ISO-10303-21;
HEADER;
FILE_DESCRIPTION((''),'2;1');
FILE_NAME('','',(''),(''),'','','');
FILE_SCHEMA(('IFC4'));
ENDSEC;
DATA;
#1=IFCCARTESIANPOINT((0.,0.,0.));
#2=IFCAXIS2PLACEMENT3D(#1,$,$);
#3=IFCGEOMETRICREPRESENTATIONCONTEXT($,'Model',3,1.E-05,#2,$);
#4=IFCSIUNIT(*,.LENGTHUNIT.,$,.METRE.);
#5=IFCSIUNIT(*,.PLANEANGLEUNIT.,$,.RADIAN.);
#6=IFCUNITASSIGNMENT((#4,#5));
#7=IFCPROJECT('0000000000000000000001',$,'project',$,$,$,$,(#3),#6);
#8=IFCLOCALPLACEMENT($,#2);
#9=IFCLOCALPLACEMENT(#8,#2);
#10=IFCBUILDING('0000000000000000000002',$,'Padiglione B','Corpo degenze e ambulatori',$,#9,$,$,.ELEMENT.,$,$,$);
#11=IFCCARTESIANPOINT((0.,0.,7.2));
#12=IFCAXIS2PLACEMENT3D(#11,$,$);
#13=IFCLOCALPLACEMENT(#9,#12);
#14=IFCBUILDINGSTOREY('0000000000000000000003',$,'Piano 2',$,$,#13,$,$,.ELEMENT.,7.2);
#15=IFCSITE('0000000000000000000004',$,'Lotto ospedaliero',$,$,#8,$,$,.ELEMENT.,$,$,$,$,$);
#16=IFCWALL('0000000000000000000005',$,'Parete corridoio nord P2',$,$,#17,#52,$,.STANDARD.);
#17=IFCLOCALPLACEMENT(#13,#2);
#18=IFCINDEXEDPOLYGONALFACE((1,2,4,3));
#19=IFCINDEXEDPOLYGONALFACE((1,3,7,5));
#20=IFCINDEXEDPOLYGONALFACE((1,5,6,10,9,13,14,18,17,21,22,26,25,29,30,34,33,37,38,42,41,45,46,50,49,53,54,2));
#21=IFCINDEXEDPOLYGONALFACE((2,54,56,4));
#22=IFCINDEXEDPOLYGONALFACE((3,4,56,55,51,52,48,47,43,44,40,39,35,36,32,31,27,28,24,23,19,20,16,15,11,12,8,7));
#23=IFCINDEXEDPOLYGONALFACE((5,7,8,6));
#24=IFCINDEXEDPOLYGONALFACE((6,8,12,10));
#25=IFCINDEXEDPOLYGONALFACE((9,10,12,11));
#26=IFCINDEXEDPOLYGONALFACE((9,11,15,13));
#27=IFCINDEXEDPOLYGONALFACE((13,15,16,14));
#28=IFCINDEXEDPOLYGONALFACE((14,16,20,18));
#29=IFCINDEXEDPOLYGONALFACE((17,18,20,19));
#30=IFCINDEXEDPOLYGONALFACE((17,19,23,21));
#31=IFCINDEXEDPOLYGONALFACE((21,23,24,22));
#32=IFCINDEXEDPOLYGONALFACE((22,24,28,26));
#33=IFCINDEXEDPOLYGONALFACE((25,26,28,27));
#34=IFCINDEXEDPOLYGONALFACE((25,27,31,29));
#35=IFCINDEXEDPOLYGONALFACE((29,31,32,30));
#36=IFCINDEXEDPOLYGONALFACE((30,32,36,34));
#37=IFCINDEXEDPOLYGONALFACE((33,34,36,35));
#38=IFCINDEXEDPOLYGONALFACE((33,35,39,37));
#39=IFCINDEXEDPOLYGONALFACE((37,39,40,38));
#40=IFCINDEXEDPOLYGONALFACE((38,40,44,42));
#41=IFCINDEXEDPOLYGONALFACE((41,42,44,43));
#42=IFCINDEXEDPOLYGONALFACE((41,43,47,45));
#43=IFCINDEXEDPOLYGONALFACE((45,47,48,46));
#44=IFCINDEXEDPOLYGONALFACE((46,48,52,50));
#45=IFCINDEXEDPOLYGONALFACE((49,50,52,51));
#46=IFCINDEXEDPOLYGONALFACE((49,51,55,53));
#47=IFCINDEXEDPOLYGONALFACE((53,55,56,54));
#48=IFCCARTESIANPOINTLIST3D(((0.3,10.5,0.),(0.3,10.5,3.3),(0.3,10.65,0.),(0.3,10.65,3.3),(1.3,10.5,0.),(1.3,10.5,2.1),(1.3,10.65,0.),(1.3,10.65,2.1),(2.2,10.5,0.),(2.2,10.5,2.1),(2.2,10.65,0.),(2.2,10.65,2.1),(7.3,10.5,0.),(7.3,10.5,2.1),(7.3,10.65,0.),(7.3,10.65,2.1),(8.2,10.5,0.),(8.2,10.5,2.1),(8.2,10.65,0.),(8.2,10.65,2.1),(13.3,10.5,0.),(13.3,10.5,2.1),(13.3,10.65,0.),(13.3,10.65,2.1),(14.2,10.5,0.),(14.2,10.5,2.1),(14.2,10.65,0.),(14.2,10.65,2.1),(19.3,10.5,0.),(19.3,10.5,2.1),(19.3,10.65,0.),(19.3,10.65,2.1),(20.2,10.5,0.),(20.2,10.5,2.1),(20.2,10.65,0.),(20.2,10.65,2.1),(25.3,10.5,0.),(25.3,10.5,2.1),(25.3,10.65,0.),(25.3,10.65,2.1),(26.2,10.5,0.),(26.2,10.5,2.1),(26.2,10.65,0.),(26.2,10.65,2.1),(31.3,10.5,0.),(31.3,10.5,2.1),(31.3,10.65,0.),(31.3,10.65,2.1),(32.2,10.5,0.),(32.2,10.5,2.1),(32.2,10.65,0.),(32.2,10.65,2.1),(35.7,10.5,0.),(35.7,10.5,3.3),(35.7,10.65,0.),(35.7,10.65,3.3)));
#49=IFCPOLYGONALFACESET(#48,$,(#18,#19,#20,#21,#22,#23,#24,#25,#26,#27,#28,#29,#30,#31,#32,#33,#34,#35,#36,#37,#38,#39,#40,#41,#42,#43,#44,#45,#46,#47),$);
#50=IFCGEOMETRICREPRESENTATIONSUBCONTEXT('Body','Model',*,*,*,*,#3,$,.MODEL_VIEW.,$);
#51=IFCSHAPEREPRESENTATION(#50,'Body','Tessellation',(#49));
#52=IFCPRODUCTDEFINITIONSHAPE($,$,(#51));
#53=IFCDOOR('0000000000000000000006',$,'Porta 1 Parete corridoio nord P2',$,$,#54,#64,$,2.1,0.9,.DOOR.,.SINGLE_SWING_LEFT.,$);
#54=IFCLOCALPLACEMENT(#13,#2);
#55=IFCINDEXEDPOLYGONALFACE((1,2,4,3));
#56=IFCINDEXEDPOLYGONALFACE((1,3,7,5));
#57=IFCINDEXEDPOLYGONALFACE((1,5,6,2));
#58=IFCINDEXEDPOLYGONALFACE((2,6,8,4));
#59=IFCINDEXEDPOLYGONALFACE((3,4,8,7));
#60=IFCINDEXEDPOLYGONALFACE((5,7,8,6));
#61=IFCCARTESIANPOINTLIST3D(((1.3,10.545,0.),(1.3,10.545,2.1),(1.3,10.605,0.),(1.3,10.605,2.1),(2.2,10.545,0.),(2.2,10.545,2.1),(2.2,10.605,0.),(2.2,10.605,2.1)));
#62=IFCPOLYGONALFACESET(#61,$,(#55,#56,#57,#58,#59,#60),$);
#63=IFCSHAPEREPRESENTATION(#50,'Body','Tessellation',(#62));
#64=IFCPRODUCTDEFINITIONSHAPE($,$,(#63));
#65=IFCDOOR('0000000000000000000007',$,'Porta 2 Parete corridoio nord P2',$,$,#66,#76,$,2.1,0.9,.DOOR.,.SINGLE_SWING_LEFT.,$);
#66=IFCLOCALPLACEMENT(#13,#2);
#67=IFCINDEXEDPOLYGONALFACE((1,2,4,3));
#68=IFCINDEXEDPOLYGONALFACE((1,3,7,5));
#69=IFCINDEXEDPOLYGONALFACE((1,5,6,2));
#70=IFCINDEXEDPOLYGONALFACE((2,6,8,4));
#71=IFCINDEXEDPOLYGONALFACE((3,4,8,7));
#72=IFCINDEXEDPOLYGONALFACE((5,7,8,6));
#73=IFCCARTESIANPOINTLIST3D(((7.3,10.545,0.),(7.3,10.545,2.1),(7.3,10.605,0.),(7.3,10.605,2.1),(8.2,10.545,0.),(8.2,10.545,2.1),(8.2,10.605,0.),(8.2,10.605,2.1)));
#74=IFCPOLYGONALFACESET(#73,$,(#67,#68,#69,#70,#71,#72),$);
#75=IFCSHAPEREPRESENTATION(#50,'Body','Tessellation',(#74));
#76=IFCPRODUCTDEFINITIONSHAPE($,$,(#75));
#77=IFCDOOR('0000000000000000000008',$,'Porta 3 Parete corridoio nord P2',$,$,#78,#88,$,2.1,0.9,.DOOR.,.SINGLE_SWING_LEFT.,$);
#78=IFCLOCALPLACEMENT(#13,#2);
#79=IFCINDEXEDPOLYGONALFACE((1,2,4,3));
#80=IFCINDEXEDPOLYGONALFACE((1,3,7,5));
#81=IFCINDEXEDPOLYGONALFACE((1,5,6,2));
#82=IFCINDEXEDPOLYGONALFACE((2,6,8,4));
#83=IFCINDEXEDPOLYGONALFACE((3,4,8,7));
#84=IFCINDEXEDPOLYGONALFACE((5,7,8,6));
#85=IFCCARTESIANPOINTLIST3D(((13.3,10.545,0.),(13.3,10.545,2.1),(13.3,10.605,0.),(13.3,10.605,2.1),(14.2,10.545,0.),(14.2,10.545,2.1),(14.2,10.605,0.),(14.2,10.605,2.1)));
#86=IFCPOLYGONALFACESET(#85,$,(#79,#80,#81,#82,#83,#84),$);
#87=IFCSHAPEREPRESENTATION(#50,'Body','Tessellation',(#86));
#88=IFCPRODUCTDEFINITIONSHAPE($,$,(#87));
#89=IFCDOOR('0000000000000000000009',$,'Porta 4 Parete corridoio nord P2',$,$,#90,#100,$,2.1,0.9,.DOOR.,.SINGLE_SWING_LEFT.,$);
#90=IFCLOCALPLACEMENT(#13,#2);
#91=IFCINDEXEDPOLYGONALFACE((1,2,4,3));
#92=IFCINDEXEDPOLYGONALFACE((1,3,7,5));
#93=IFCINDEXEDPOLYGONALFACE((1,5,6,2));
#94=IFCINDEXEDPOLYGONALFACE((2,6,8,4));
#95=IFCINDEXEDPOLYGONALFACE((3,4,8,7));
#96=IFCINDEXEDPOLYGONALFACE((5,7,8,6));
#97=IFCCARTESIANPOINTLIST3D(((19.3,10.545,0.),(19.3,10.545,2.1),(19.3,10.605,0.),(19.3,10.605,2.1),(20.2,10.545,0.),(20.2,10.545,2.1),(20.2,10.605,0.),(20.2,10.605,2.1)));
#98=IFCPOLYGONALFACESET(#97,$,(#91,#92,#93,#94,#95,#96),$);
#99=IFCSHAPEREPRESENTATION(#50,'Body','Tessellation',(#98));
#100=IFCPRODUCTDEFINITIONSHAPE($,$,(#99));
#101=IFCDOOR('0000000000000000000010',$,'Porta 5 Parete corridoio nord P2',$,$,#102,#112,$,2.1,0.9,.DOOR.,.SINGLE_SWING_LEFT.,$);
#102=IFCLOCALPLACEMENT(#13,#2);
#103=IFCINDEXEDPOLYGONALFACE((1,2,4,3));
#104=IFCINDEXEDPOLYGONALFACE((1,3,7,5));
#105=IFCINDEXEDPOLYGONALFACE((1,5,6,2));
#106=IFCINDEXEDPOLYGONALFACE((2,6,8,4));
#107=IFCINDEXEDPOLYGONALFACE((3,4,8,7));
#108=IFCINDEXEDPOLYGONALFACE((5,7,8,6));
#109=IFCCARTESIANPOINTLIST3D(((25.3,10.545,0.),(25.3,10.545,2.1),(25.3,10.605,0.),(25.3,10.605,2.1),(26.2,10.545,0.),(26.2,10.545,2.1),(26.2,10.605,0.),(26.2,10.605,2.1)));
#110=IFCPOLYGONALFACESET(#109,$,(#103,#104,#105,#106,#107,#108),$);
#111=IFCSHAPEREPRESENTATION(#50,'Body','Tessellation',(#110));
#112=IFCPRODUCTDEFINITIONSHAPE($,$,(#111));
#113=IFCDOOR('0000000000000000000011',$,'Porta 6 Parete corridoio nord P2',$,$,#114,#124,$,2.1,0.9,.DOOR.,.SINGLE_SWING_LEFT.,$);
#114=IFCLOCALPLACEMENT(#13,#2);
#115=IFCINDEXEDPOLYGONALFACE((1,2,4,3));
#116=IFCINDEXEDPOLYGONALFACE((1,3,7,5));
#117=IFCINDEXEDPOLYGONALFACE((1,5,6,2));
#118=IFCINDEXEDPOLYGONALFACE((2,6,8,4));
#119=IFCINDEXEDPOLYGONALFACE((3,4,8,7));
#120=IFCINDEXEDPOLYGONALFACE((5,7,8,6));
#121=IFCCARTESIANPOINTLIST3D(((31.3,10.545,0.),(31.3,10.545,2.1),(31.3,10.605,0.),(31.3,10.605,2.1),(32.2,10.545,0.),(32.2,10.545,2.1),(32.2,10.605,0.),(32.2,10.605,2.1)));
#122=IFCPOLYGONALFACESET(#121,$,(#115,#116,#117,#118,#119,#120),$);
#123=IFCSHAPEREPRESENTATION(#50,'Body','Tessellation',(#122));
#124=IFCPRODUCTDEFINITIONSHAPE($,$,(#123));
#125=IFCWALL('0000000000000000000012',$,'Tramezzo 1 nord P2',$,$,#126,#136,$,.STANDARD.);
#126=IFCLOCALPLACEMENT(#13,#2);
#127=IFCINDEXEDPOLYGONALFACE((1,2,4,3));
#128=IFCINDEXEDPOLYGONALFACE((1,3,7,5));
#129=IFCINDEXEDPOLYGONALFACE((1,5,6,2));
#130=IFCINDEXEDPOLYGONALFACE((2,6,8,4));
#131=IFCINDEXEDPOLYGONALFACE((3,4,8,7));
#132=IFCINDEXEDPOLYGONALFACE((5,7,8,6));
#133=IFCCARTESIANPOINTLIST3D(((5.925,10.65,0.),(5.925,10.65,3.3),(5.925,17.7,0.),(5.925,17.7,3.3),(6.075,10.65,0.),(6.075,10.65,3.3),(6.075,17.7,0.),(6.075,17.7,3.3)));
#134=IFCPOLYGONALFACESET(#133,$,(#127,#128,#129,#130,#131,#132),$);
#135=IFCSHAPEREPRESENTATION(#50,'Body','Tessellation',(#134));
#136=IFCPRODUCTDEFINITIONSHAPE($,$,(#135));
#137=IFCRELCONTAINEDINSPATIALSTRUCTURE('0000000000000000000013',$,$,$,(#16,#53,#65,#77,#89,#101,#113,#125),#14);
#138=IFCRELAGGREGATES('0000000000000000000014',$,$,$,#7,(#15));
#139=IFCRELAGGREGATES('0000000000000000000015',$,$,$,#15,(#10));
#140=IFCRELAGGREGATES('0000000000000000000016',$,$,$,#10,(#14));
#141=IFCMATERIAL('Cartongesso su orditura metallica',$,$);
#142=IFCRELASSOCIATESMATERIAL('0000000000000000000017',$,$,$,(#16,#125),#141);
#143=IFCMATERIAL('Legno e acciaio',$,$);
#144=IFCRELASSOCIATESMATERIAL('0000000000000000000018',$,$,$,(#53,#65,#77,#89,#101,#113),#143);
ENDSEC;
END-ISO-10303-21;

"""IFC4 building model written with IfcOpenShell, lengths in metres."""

from ifc_helpers import new_model, si_unit, frame, frame_2d, origin, place, context, subcontext, project, spatial, rectangle, extrude, material, element, fill, save


model = new_model("IFC4")

# Units and contexts
model_context = context("Model", 3, precision=1e-05, world=origin())
body_context = subcontext(model_context, "Body", "Model", "MODEL_VIEW")
ifc_project = project(units=[si_unit("LENGTHUNIT", "METRE"), si_unit("PLANEANGLEUNIT", "RADIAN")], contexts=[model_context])

# Site, building, storey
site_placement = place(None, origin())
site = spatial("IfcSite", under=ifc_project, at=site_placement, Name="Lotto ospedaliero", CompositionType="ELEMENT")
building_placement = place(site_placement, origin())
building = spatial("IfcBuilding", under=site, at=building_placement, Name="Padiglione B", Description="Corpo degenze e ambulatori", CompositionType="ELEMENT")
storey_placement = place(building_placement, frame((0.0, 0.0, 7.2)))
storey = spatial("IfcBuildingStorey", under=building, at=storey_placement, Name="Piano 2", CompositionType="ELEMENT", Elevation=7.2)

# Wall, openings, doors
ifc_material_1 = material(Name="Cartongesso su orditura metallica")
ifc_material_2 = material(Name="Legno e acciaio")
wall_1_placement = place(storey_placement, frame((0.3, 10.5, 0.0)))
wall_1 = element("IfcWall", 1, at=wall_1_placement, inside=storey, material=ifc_material_1, Name="Parete corridoio nord P2", PredefinedType="STANDARD", context=body_context, shape_type="SweptSolid", body=[
    extrude(rectangle(XDim=35.4, YDim=0.15, at=frame_2d((17.7, 0.075))), origin(), (0.0, 0.0, 1.0), 3.3),
])
opening_1_placement = place(wall_1_placement, frame((1.0, -0.1, 0.0)))
opening_1 = element("IfcOpeningElement", 2, at=opening_1_placement, cuts=wall_1, PredefinedType="OPENING", context=body_context, shape_type="SweptSolid", body=[
    extrude(rectangle(XDim=0.9, YDim=0.35, at=frame_2d((0.45, 0.175))), origin(), (0.0, 0.0, 1.0), 2.1),
])
opening_2_placement = place(wall_1_placement, frame((7.0, -0.1, 0.0)))
opening_2 = element("IfcOpeningElement", 3, at=opening_2_placement, cuts=wall_1, PredefinedType="OPENING", context=body_context, shape_type="SweptSolid", body=[
    extrude(rectangle(XDim=0.9, YDim=0.35, at=frame_2d((0.45, 0.175))), origin(), (0.0, 0.0, 1.0), 2.1),
])
opening_3_placement = place(wall_1_placement, frame((13.0, -0.1, 0.0)))
opening_3 = element("IfcOpeningElement", 4, at=opening_3_placement, cuts=wall_1, PredefinedType="OPENING", context=body_context, shape_type="SweptSolid", body=[
    extrude(rectangle(XDim=0.9, YDim=0.35, at=frame_2d((0.45, 0.175))), origin(), (0.0, 0.0, 1.0), 2.1),
])
opening_4_placement = place(wall_1_placement, frame((19.0, -0.1, 0.0)))
opening_4 = element("IfcOpeningElement", 5, at=opening_4_placement, cuts=wall_1, PredefinedType="OPENING", context=body_context, shape_type="SweptSolid", body=[
    extrude(rectangle(XDim=0.9, YDim=0.35, at=frame_2d((0.45, 0.175))), origin(), (0.0, 0.0, 1.0), 2.1),
])
opening_5_placement = place(wall_1_placement, frame((25.0, -0.1, 0.0)))
opening_5 = element("IfcOpeningElement", 6, at=opening_5_placement, cuts=wall_1, PredefinedType="OPENING", context=body_context, shape_type="SweptSolid", body=[
    extrude(rectangle(XDim=0.9, YDim=0.35, at=frame_2d((0.45, 0.175))), origin(), (0.0, 0.0, 1.0), 2.1),
])
opening_6_placement = place(wall_1_placement, frame((31.0, -0.1, 0.0)))
opening_6 = element("IfcOpeningElement", 7, at=opening_6_placement, cuts=wall_1, PredefinedType="OPENING", context=body_context, shape_type="SweptSolid", body=[
    extrude(rectangle(XDim=0.9, YDim=0.35, at=frame_2d((0.45, 0.175))), origin(), (0.0, 0.0, 1.0), 2.1),
])
door_1_placement = place(wall_1_placement, frame((1.0, 0.045, 0.0)))
door_1 = element("IfcDoor", 8, at=door_1_placement, inside=storey, material=ifc_material_2, Name="Porta 1 Parete corridoio nord P2", OperationType="SINGLE_SWING_LEFT", OverallHeight=2.1, OverallWidth=0.9, PredefinedType="DOOR", context=body_context, shape_type="SweptSolid", body=[
    extrude(rectangle(XDim=0.9, YDim=0.06, at=frame_2d((0.45, 0.03))), origin(), (0.0, 0.0, 1.0), 2.1),
])
fill(opening_1, door_1)
door_2_placement = place(wall_1_placement, frame((7.0, 0.045, 0.0)))
door_2 = element("IfcDoor", 9, at=door_2_placement, inside=storey, material=ifc_material_2, Name="Porta 2 Parete corridoio nord P2", OperationType="SINGLE_SWING_LEFT", OverallHeight=2.1, OverallWidth=0.9, PredefinedType="DOOR", context=body_context, shape_type="SweptSolid", body=[
    extrude(rectangle(XDim=0.9, YDim=0.06, at=frame_2d((0.45, 0.03))), origin(), (0.0, 0.0, 1.0), 2.1),
])
fill(opening_2, door_2)
door_3_placement = place(wall_1_placement, frame((13.0, 0.045, 0.0)))
door_3 = element("IfcDoor", 10, at=door_3_placement, inside=storey, material=ifc_material_2, Name="Porta 3 Parete corridoio nord P2", OperationType="SINGLE_SWING_LEFT", OverallHeight=2.1, OverallWidth=0.9, PredefinedType="DOOR", context=body_context, shape_type="SweptSolid", body=[
    extrude(rectangle(XDim=0.9, YDim=0.06, at=frame_2d((0.45, 0.03))), origin(), (0.0, 0.0, 1.0), 2.1),
])
fill(opening_3, door_3)
door_4_placement = place(wall_1_placement, frame((19.0, 0.045, 0.0)))
door_4 = element("IfcDoor", 11, at=door_4_placement, inside=storey, material=ifc_material_2, Name="Porta 4 Parete corridoio nord P2", OperationType="SINGLE_SWING_LEFT", OverallHeight=2.1, OverallWidth=0.9, PredefinedType="DOOR", context=body_context, shape_type="SweptSolid", body=[
    extrude(rectangle(XDim=0.9, YDim=0.06, at=frame_2d((0.45, 0.03))), origin(), (0.0, 0.0, 1.0), 2.1),
])
fill(opening_4, door_4)
door_5_placement = place(wall_1_placement, frame((25.0, 0.045, 0.0)))
door_5 = element("IfcDoor", 12, at=door_5_placement, inside=storey, material=ifc_material_2, Name="Porta 5 Parete corridoio nord P2", OperationType="SINGLE_SWING_LEFT", OverallHeight=2.1, OverallWidth=0.9, PredefinedType="DOOR", context=body_context, shape_type="SweptSolid", body=[
    extrude(rectangle(XDim=0.9, YDim=0.06, at=frame_2d((0.45, 0.03))), origin(), (0.0, 0.0, 1.0), 2.1),
])
fill(opening_5, door_5)
door_6_placement = place(wall_1_placement, frame((31.0, 0.045, 0.0)))
door_6 = element("IfcDoor", 13, at=door_6_placement, inside=storey, material=ifc_material_2, Name="Porta 6 Parete corridoio nord P2", OperationType="SINGLE_SWING_LEFT", OverallHeight=2.1, OverallWidth=0.9, PredefinedType="DOOR", context=body_context, shape_type="SweptSolid", body=[
    extrude(rectangle(XDim=0.9, YDim=0.06, at=frame_2d((0.45, 0.03))), origin(), (0.0, 0.0, 1.0), 2.1),
])
fill(opening_6, door_6)

# Wall
wall_2_placement = place(storey_placement, frame((5.925, 10.65, 0.0)))
element("IfcWall", 14, at=wall_2_placement, inside=storey, material=ifc_material_1, Name="Tramezzo 1 nord P2", PredefinedType="STANDARD", context=body_context, shape_type="SweptSolid", body=[
    extrude(rectangle(XDim=0.15, YDim=7.05, at=frame_2d((0.075, 3.525))), origin(), (0.0, 0.0, 1.0), 3.3),
])

save(model, "model.ifc")
